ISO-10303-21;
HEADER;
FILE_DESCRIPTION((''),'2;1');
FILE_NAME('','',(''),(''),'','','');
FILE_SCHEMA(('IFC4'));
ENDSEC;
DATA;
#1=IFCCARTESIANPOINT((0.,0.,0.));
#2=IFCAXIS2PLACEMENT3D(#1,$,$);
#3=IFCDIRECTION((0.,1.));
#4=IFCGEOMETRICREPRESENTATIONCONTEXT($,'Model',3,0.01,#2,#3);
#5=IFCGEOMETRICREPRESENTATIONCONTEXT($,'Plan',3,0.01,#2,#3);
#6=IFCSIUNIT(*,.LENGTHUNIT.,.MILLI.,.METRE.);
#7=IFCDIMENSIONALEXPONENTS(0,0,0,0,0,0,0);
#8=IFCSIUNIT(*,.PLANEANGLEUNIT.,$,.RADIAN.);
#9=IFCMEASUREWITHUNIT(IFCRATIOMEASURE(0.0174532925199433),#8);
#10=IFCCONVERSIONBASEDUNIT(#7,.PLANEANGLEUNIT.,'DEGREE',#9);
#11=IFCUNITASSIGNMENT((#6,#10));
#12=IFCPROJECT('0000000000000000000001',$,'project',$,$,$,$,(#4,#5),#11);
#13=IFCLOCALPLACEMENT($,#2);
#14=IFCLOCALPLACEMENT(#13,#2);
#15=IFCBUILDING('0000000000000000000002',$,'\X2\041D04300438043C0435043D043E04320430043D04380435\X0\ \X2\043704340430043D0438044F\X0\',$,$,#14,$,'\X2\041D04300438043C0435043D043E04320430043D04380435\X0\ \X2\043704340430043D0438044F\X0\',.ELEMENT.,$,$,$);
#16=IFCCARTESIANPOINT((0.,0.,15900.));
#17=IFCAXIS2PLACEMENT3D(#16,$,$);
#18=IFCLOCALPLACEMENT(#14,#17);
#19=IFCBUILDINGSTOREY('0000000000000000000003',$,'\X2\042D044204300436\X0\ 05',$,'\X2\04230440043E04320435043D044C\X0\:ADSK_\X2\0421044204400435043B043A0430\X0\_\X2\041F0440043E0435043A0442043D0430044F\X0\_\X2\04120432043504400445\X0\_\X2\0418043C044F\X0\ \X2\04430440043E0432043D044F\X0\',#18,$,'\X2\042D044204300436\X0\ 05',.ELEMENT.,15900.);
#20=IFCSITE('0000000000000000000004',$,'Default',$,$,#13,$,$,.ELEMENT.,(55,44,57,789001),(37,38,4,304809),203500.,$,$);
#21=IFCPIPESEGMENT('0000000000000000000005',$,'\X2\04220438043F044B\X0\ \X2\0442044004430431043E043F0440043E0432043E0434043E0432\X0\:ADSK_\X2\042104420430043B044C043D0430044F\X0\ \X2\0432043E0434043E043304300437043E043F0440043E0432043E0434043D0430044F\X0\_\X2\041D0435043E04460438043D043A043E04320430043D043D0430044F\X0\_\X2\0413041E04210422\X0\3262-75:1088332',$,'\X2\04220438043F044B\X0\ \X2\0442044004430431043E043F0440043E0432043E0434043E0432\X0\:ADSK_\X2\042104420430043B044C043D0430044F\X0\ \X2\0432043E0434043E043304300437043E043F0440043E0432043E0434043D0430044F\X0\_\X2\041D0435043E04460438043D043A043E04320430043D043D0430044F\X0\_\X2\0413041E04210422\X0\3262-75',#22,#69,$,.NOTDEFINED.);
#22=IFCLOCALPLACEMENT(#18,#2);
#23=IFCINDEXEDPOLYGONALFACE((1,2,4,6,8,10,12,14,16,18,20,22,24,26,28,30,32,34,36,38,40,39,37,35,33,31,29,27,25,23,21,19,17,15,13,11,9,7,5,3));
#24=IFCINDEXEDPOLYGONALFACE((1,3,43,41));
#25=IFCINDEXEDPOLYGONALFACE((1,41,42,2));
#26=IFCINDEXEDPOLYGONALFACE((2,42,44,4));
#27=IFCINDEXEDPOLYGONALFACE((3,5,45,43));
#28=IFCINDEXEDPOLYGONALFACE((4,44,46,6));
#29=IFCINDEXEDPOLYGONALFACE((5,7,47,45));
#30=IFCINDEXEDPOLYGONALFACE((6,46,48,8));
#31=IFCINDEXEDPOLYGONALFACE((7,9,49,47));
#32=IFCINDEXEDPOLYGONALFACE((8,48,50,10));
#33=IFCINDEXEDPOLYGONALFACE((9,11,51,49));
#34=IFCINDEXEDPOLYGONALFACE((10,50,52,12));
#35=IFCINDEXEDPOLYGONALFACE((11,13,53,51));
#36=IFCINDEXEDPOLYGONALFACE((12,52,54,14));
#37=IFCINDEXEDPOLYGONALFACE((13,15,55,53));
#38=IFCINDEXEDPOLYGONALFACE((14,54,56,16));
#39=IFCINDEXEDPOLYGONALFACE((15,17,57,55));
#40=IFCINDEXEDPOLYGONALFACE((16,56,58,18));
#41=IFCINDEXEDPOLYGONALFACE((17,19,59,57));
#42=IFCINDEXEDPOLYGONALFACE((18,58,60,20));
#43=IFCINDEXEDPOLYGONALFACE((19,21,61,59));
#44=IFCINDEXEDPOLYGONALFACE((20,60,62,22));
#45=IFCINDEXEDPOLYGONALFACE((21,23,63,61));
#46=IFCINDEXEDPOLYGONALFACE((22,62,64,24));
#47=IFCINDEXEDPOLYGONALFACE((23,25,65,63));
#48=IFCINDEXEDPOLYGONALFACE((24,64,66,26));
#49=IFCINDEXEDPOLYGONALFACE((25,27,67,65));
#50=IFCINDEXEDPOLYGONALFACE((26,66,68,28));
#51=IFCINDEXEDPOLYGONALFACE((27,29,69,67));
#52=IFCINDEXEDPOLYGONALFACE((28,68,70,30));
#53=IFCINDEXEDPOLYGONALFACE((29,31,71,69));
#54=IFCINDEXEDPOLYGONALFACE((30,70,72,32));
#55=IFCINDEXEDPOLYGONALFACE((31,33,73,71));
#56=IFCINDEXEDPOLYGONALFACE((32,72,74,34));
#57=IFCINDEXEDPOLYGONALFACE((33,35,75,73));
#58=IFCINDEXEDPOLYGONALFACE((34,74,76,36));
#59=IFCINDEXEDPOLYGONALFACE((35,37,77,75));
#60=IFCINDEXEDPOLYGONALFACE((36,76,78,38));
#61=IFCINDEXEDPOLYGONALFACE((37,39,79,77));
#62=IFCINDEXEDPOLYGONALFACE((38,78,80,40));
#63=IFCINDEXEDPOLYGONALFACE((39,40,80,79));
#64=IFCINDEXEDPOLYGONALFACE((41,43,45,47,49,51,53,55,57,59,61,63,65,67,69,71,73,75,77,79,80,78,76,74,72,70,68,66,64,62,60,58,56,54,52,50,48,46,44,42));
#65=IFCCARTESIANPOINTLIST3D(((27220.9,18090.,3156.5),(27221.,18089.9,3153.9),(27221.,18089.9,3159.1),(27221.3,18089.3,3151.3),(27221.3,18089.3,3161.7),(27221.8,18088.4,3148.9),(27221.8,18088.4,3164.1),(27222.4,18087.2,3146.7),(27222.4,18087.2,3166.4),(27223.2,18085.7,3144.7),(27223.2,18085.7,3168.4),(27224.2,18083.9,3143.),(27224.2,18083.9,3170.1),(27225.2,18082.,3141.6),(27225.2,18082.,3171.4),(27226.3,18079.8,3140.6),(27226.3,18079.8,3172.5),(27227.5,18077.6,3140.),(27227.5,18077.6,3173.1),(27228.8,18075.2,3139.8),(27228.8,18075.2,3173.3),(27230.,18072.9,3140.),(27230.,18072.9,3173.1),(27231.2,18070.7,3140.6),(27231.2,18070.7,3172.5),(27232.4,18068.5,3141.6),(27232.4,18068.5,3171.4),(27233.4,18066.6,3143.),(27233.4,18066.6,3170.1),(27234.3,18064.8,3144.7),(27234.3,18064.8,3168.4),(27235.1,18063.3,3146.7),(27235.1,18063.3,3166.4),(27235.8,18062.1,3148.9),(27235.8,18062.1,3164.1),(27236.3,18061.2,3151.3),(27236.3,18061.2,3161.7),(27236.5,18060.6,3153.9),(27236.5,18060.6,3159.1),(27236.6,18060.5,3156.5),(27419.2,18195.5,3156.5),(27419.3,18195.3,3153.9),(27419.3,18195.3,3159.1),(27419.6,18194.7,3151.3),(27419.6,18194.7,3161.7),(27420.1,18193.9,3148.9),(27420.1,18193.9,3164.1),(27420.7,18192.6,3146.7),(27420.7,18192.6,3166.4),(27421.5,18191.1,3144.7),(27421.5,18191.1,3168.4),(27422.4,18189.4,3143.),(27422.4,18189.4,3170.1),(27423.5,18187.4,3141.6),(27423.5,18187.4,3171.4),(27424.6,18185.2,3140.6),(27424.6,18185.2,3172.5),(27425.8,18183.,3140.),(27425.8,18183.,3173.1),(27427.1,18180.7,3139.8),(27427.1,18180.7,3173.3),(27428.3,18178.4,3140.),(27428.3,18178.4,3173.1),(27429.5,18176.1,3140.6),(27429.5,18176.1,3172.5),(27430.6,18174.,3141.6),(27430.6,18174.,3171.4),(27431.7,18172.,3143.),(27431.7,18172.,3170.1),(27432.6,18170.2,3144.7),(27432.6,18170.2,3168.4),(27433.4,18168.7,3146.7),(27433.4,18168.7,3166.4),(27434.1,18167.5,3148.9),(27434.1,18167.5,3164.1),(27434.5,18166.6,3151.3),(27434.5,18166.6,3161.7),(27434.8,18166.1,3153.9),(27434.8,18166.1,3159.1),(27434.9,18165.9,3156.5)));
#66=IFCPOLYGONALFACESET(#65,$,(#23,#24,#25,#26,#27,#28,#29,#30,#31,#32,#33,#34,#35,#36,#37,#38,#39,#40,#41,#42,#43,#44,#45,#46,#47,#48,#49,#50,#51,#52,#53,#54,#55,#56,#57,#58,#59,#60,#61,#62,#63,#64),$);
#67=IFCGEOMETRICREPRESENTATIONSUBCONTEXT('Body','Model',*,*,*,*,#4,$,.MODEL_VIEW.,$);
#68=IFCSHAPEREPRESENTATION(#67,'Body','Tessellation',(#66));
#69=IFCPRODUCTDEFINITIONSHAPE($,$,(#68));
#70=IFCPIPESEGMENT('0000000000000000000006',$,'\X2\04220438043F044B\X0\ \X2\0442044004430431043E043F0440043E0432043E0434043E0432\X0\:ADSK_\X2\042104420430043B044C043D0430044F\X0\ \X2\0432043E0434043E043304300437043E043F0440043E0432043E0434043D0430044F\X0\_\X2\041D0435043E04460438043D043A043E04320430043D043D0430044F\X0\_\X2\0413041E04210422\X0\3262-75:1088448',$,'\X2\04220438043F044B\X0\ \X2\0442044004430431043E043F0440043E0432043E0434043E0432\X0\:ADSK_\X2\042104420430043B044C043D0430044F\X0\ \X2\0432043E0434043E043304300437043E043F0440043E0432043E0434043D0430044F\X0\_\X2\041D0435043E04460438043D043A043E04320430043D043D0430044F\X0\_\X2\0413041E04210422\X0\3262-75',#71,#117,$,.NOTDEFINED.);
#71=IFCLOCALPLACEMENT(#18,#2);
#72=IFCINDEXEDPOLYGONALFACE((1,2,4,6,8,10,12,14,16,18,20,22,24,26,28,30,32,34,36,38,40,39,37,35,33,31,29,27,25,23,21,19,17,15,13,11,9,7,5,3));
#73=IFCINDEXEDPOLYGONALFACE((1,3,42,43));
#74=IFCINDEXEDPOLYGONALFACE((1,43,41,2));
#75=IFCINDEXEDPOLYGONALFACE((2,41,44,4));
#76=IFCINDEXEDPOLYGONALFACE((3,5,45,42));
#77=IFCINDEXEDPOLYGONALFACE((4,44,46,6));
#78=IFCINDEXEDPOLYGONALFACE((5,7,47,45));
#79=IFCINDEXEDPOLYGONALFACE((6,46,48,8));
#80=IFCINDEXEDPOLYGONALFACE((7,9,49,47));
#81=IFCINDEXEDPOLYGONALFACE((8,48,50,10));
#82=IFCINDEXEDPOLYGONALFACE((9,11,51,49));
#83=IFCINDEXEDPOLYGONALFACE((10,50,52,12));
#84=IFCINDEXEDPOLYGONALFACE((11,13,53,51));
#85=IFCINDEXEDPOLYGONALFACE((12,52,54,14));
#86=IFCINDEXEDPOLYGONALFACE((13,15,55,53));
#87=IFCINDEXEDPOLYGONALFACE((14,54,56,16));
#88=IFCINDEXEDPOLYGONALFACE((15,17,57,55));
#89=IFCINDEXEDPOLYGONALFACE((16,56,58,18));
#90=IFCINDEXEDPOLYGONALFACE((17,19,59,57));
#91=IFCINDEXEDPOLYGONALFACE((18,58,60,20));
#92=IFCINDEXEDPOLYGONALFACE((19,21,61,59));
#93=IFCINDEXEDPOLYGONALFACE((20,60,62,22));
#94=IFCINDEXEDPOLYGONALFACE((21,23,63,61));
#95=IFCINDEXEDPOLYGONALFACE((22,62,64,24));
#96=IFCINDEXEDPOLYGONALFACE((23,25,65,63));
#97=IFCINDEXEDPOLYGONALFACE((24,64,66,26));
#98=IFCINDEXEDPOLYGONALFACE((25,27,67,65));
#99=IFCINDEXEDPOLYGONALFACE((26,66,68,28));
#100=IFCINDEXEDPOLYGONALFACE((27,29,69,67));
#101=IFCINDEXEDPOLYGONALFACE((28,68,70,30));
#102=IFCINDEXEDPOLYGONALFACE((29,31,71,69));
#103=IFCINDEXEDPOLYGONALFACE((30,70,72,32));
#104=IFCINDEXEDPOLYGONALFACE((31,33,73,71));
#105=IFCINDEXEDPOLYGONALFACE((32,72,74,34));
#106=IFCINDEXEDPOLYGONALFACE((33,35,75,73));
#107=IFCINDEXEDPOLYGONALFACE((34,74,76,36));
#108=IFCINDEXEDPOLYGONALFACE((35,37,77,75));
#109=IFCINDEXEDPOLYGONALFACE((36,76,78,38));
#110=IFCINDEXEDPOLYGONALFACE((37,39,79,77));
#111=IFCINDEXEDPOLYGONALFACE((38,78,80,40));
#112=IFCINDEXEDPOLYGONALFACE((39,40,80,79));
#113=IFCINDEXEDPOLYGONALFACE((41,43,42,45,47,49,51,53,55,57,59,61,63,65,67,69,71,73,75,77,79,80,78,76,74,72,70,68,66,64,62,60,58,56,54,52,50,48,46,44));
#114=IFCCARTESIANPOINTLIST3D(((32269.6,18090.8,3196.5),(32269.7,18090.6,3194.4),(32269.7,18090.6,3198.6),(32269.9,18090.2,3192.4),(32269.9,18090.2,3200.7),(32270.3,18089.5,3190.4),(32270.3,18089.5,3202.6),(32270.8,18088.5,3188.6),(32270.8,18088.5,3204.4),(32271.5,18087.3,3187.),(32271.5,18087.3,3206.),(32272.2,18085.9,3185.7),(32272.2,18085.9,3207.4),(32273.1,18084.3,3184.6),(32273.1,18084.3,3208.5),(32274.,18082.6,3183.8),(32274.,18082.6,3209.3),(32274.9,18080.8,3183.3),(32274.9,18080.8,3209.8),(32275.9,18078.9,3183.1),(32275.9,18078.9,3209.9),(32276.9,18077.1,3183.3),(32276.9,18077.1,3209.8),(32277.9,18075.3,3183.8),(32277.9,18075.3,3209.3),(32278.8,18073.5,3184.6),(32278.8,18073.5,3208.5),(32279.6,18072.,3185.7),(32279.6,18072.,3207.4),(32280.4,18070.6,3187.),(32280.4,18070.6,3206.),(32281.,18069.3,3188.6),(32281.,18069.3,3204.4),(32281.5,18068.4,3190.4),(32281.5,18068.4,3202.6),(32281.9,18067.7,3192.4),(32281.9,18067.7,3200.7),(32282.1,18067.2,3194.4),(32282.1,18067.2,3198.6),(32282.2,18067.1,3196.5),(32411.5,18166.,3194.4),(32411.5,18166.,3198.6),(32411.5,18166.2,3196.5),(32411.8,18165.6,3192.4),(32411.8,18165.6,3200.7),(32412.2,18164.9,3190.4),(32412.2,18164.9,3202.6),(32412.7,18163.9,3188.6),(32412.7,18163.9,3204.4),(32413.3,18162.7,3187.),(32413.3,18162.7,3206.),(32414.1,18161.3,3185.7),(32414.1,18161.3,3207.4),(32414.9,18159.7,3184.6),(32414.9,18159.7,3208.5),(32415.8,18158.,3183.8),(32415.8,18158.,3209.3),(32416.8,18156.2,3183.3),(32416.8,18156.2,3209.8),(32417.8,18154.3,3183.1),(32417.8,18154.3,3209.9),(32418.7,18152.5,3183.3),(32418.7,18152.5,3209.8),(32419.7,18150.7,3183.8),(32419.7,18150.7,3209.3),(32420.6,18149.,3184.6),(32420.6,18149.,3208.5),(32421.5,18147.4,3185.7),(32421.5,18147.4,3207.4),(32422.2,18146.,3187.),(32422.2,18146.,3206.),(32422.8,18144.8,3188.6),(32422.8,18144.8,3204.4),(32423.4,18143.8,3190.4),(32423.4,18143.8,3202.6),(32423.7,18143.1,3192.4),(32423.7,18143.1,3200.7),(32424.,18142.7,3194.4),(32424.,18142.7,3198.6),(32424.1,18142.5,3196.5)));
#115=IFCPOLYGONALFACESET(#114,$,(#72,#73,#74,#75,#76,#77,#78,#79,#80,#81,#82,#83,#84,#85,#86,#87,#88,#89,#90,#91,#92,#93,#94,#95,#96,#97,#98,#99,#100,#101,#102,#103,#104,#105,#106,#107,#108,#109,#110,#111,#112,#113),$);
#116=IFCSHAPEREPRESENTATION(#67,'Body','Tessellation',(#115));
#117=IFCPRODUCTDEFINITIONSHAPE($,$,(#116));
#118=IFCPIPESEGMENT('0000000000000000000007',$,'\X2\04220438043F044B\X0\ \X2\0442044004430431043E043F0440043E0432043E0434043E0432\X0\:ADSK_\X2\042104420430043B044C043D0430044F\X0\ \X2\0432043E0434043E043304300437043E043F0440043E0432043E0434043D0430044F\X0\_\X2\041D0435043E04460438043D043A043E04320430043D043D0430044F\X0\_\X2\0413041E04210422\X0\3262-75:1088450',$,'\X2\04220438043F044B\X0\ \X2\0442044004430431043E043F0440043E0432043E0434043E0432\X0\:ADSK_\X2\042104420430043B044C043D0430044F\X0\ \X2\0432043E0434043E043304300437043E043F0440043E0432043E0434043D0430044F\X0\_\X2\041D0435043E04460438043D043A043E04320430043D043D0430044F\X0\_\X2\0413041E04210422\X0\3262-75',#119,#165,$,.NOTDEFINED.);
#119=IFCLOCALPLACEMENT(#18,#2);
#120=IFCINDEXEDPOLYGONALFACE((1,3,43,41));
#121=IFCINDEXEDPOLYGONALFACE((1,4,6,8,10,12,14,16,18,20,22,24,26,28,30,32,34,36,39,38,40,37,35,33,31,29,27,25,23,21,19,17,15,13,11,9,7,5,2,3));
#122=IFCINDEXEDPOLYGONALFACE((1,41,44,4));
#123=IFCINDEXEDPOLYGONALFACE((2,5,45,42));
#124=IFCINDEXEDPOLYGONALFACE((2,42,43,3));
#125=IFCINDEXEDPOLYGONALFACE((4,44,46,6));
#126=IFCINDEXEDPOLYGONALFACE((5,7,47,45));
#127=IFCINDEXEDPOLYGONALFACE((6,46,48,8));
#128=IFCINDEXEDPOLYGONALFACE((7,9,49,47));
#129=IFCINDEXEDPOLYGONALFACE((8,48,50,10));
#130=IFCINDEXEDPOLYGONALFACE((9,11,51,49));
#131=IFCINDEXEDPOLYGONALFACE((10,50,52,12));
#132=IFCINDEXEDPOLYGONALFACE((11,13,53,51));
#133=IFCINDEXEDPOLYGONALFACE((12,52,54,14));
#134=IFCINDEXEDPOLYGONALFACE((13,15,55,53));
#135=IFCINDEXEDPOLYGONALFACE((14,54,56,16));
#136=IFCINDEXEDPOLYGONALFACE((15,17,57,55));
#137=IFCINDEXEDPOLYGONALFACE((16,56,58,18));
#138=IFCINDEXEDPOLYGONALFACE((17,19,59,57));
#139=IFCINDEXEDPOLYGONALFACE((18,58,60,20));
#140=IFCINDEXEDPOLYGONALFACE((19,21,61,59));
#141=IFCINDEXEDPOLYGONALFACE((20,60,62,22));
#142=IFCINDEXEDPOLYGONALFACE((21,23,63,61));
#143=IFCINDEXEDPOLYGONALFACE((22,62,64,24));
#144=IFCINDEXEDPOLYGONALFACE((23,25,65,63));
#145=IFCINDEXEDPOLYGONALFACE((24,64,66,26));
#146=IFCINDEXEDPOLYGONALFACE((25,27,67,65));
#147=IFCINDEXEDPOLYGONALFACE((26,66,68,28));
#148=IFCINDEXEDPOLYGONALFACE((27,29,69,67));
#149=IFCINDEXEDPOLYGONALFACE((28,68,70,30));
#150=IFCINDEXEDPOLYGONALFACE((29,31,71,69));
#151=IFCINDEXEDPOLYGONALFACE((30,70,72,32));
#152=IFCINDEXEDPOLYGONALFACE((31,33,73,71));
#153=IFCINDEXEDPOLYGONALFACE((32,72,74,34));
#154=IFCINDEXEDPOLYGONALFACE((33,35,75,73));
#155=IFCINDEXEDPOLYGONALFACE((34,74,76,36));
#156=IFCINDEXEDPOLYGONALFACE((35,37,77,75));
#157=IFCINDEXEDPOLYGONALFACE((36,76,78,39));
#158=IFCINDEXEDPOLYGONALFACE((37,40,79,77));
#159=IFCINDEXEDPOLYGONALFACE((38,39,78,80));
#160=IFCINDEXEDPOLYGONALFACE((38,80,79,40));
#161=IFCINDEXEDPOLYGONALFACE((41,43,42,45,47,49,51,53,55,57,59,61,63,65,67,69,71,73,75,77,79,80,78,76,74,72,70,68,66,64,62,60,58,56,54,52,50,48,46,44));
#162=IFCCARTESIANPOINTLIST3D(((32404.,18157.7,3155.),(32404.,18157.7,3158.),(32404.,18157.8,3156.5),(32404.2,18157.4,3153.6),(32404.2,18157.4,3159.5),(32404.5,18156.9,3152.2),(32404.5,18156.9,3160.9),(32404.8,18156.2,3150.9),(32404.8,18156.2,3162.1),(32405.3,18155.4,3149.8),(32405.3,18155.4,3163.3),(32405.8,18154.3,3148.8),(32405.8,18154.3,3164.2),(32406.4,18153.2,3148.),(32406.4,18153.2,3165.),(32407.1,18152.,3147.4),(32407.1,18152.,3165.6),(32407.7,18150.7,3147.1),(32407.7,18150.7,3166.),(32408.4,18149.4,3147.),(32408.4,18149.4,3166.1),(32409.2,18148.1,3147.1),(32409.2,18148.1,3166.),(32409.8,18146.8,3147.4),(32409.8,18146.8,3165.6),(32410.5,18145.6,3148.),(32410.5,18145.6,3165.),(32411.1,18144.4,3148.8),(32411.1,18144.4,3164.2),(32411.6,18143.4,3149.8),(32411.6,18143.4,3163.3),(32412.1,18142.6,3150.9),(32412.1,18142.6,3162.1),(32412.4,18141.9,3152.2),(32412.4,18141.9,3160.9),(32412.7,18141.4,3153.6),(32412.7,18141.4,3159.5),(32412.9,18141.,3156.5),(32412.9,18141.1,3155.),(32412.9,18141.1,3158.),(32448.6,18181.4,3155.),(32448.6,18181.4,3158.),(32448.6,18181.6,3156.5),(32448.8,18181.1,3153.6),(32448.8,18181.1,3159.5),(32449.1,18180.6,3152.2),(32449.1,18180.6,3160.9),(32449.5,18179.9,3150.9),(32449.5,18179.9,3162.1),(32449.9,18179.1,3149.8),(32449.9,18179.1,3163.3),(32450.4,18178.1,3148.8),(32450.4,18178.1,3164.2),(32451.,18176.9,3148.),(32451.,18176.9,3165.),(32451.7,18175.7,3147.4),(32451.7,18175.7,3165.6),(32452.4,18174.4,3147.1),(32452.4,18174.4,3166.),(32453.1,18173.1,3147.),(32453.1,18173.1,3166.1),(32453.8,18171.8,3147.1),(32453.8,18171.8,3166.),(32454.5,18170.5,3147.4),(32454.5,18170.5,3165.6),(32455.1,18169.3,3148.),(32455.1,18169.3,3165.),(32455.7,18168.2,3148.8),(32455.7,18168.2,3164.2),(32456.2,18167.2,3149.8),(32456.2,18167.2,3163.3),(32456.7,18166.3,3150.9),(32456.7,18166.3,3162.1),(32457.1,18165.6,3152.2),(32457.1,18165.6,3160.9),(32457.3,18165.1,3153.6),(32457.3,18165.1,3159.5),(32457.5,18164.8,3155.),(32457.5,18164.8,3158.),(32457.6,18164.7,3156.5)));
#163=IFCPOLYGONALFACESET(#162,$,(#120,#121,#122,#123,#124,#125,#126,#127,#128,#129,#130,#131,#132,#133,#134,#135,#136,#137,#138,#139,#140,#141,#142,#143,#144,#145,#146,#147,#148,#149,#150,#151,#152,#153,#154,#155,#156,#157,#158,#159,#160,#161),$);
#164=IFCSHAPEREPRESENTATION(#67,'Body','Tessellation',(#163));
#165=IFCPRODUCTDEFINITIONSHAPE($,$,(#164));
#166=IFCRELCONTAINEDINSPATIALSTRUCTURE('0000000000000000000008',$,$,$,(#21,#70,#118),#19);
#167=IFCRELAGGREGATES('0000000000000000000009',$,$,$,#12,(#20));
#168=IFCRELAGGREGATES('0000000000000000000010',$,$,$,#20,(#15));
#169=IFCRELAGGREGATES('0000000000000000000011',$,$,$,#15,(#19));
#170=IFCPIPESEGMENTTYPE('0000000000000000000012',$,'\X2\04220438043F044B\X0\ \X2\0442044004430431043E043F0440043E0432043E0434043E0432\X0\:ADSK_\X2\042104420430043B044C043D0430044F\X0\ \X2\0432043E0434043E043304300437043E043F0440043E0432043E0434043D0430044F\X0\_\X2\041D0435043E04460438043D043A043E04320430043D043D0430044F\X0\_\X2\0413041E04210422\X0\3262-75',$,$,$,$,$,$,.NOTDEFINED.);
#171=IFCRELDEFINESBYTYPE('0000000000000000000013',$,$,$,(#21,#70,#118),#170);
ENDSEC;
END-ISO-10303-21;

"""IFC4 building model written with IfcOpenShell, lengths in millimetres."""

from ifc_helpers import new_model, entity, si_unit, converted_unit, direction, frame, origin, place, context, subcontext, project, spatial, indexed_curve, outline, extrude, type_object, element, save


model = new_model("IFC4")

# Units and contexts
model_context = context("Model", 3, precision=0.01, world=origin(), true_north=direction((0.0, 1.0)))
plan_context = context("Plan", 3, precision=0.01, world=origin(), true_north=direction((0.0, 1.0)))
body_context = subcontext(model_context, "Body", "Model", "MODEL_VIEW")
ifc_project = project(units=[si_unit("LENGTHUNIT", "METRE", prefix="MILLI"), converted_unit("PLANEANGLEUNIT", "DEGREE", entity("IfcRatioMeasure", 0.0174532925199433), si_unit("PLANEANGLEUNIT", "RADIAN"), dimensions=[0, 0, 0, 0, 0, 0, 0])], contexts=[model_context, plan_context])

# Site, building, storey
site_placement = place(None, origin())
site = spatial("IfcSite", under=ifc_project, at=site_placement, Name="Default", CompositionType="ELEMENT", RefLatitude=(55, 44, 57, 789001), RefLongitude=(37, 38, 4, 304809), RefElevation=203500.0)
building_placement = place(site_placement, origin())
building = spatial("IfcBuilding", under=site, at=building_placement, Name="Наименование здания", LongName="Наименование здания", CompositionType="ELEMENT")
storey_placement = place(building_placement, frame((0.0, 0.0, 15900.0)))
storey = spatial("IfcBuildingStorey", under=building, at=storey_placement, Name="Этаж 05", ObjectType="Уровень:ADSK_Стрелка_Проектная_Вверх_Имя уровня", LongName="Этаж 05", CompositionType="ELEMENT", Elevation=15900.0)

# Pipe segments
placement = place(storey_placement, origin())
pipe_segment_type_1 = type_object("IfcPipeSegmentType", Name="Типы трубопроводов:ADSK_Стальная водогазопроводная_Неоцинкованная_ГОСТ3262-75", PredefinedType="NOTDEFINED")
element("IfcPipeSegment", 1, at=placement, inside=storey, type_object=pipe_segment_type_1, Name="Типы трубопроводов:ADSK_Стальная водогазопроводная_Неоцинкованная_ГОСТ3262-75:1088332", ObjectType="Типы трубопроводов:ADSK_Стальная водогазопроводная_Неоцинкованная_ГОСТ3262-75", PredefinedType="NOTDEFINED", context=body_context, shape_type="SweptSolid", body=[
    extrude(outline(indexed_curve([(16.7, 0.0), (16.5, 2.6), (15.9, 5.2), (14.9, 7.6), (13.6, 9.8), (11.8, 11.8), (9.8, 13.6), (7.6, 14.9), (5.2, 15.9), (2.6, 16.5), (0.0, 16.8), (-2.6, 16.5), (-5.2, 15.9), (-7.6, 14.9), (-9.8, 13.6), (-11.8, 11.8), (-13.6, 9.8), (-14.9, 7.6), (-15.9, 5.2), (-16.5, 2.6), (-16.7, 0.0), (-16.5, -2.6), (-15.9, -5.2), (-14.9, -7.6), (-13.6, -9.8), (-11.8, -11.8), (-9.8, -13.6), (-7.6, -14.9), (-5.2, -15.9), (-2.6, -16.5), (0.0, -16.8), (2.6, -16.5), (5.2, -15.9), (7.6, -14.9), (9.8, -13.6), (11.8, -11.8), (13.6, -9.8), (14.9, -7.6), (15.9, -5.2), (16.5, -2.6), (16.7, 0.0)], self_intersect=False)), frame((27228.8, 18075.2, 3156.5), z_axis=(0.882948, 0.469472, 0.0), x_axis=(0.469472, -0.882948, 0.0)), (0.0, 0.0, 1.0), 224.6),
])
element("IfcPipeSegment", 2, at=placement, inside=storey, type_object=pipe_segment_type_1, Name="Типы трубопроводов:ADSK_Стальная водогазопроводная_Неоцинкованная_ГОСТ3262-75:1088448", ObjectType="Типы трубопроводов:ADSK_Стальная водогазопроводная_Неоцинкованная_ГОСТ3262-75", PredefinedType="NOTDEFINED", context=body_context, shape_type="SweptSolid", body=[
    extrude(outline(indexed_curve([(13.4, 0.0), (13.2, 2.1), (12.7, 4.1), (11.9, 6.1), (10.8, 7.9), (9.5, 9.5), (7.9, 10.8), (6.1, 11.9), (4.1, 12.7), (2.1, 13.2), (0.0, 13.4), (-2.1, 13.2), (-4.1, 12.7), (-6.1, 11.9), (-7.9, 10.8), (-9.5, 9.5), (-10.8, 7.9), (-11.9, 6.1), (-12.7, 4.1), (-13.2, 2.1), (-13.4, 0.0), (-13.2, -2.1), (-12.7, -4.1), (-11.9, -6.1), (-10.8, -7.9), (-9.5, -9.5), (-7.9, -10.8), (-6.1, -11.9), (-4.1, -12.7), (-2.1, -13.2), (0.0, -13.4), (2.1, -13.2), (4.1, -12.7), (6.1, -11.9), (7.9, -10.8), (9.5, -9.5), (10.8, -7.9), (11.9, -6.1), (12.7, -4.1), (13.2, -2.1), (13.4, 0.0)], self_intersect=False)), frame((32275.9, 18078.9, 3196.5), z_axis=(0.882948, 0.469472, 0.0), x_axis=(0.469472, -0.882948, 0.0)), (0.0, 0.0, 1.0), 160.6),
])
element("IfcPipeSegment", 3, at=placement, inside=storey, type_object=pipe_segment_type_1, Name="Типы трубопроводов:ADSK_Стальная водогазопроводная_Неоцинкованная_ГОСТ3262-75:1088450", ObjectType="Типы трубопроводов:ADSK_Стальная водогазопроводная_Неоцинкованная_ГОСТ3262-75", PredefinedType="NOTDEFINED", context=body_context, shape_type="SweptSolid", body=[
    extrude(outline(indexed_curve([(9.6, 0.0), (9.4, 1.5), (9.1, 3.0), (8.5, 4.3), (7.7, 5.6), (6.8, 6.8), (5.6, 7.7), (4.3, 8.5), (3.0, 9.1), (1.5, 9.4), (0.0, 9.6), (-1.5, 9.4), (-3.0, 9.1), (-4.3, 8.5), (-5.6, 7.7), (-6.8, 6.8), (-7.7, 5.6), (-8.5, 4.3), (-9.1, 3.0), (-9.4, 1.5), (-9.5, 0.0), (-9.4, -1.5), (-9.1, -3.0), (-8.5, -4.3), (-7.7, -5.6), (-6.8, -6.8), (-5.6, -7.7), (-4.3, -8.5), (-3.0, -9.1), (-1.5, -9.4), (0.0, -9.6), (1.5, -9.4), (3.0, -9.1), (4.3, -8.5), (5.6, -7.7), (6.8, -6.8), (7.7, -5.6), (8.5, -4.3), (9.1, -3.0), (9.4, -1.5), (9.6, 0.0)], self_intersect=False)), frame((32408.5, 18149.4, 3156.5), z_axis=(0.882948, 0.469472, 0.0), x_axis=(-0.469472, 0.882948, 0.0)), (0.0, 0.0, 1.0), 50.5),
])

save(model, "model.ifc")
